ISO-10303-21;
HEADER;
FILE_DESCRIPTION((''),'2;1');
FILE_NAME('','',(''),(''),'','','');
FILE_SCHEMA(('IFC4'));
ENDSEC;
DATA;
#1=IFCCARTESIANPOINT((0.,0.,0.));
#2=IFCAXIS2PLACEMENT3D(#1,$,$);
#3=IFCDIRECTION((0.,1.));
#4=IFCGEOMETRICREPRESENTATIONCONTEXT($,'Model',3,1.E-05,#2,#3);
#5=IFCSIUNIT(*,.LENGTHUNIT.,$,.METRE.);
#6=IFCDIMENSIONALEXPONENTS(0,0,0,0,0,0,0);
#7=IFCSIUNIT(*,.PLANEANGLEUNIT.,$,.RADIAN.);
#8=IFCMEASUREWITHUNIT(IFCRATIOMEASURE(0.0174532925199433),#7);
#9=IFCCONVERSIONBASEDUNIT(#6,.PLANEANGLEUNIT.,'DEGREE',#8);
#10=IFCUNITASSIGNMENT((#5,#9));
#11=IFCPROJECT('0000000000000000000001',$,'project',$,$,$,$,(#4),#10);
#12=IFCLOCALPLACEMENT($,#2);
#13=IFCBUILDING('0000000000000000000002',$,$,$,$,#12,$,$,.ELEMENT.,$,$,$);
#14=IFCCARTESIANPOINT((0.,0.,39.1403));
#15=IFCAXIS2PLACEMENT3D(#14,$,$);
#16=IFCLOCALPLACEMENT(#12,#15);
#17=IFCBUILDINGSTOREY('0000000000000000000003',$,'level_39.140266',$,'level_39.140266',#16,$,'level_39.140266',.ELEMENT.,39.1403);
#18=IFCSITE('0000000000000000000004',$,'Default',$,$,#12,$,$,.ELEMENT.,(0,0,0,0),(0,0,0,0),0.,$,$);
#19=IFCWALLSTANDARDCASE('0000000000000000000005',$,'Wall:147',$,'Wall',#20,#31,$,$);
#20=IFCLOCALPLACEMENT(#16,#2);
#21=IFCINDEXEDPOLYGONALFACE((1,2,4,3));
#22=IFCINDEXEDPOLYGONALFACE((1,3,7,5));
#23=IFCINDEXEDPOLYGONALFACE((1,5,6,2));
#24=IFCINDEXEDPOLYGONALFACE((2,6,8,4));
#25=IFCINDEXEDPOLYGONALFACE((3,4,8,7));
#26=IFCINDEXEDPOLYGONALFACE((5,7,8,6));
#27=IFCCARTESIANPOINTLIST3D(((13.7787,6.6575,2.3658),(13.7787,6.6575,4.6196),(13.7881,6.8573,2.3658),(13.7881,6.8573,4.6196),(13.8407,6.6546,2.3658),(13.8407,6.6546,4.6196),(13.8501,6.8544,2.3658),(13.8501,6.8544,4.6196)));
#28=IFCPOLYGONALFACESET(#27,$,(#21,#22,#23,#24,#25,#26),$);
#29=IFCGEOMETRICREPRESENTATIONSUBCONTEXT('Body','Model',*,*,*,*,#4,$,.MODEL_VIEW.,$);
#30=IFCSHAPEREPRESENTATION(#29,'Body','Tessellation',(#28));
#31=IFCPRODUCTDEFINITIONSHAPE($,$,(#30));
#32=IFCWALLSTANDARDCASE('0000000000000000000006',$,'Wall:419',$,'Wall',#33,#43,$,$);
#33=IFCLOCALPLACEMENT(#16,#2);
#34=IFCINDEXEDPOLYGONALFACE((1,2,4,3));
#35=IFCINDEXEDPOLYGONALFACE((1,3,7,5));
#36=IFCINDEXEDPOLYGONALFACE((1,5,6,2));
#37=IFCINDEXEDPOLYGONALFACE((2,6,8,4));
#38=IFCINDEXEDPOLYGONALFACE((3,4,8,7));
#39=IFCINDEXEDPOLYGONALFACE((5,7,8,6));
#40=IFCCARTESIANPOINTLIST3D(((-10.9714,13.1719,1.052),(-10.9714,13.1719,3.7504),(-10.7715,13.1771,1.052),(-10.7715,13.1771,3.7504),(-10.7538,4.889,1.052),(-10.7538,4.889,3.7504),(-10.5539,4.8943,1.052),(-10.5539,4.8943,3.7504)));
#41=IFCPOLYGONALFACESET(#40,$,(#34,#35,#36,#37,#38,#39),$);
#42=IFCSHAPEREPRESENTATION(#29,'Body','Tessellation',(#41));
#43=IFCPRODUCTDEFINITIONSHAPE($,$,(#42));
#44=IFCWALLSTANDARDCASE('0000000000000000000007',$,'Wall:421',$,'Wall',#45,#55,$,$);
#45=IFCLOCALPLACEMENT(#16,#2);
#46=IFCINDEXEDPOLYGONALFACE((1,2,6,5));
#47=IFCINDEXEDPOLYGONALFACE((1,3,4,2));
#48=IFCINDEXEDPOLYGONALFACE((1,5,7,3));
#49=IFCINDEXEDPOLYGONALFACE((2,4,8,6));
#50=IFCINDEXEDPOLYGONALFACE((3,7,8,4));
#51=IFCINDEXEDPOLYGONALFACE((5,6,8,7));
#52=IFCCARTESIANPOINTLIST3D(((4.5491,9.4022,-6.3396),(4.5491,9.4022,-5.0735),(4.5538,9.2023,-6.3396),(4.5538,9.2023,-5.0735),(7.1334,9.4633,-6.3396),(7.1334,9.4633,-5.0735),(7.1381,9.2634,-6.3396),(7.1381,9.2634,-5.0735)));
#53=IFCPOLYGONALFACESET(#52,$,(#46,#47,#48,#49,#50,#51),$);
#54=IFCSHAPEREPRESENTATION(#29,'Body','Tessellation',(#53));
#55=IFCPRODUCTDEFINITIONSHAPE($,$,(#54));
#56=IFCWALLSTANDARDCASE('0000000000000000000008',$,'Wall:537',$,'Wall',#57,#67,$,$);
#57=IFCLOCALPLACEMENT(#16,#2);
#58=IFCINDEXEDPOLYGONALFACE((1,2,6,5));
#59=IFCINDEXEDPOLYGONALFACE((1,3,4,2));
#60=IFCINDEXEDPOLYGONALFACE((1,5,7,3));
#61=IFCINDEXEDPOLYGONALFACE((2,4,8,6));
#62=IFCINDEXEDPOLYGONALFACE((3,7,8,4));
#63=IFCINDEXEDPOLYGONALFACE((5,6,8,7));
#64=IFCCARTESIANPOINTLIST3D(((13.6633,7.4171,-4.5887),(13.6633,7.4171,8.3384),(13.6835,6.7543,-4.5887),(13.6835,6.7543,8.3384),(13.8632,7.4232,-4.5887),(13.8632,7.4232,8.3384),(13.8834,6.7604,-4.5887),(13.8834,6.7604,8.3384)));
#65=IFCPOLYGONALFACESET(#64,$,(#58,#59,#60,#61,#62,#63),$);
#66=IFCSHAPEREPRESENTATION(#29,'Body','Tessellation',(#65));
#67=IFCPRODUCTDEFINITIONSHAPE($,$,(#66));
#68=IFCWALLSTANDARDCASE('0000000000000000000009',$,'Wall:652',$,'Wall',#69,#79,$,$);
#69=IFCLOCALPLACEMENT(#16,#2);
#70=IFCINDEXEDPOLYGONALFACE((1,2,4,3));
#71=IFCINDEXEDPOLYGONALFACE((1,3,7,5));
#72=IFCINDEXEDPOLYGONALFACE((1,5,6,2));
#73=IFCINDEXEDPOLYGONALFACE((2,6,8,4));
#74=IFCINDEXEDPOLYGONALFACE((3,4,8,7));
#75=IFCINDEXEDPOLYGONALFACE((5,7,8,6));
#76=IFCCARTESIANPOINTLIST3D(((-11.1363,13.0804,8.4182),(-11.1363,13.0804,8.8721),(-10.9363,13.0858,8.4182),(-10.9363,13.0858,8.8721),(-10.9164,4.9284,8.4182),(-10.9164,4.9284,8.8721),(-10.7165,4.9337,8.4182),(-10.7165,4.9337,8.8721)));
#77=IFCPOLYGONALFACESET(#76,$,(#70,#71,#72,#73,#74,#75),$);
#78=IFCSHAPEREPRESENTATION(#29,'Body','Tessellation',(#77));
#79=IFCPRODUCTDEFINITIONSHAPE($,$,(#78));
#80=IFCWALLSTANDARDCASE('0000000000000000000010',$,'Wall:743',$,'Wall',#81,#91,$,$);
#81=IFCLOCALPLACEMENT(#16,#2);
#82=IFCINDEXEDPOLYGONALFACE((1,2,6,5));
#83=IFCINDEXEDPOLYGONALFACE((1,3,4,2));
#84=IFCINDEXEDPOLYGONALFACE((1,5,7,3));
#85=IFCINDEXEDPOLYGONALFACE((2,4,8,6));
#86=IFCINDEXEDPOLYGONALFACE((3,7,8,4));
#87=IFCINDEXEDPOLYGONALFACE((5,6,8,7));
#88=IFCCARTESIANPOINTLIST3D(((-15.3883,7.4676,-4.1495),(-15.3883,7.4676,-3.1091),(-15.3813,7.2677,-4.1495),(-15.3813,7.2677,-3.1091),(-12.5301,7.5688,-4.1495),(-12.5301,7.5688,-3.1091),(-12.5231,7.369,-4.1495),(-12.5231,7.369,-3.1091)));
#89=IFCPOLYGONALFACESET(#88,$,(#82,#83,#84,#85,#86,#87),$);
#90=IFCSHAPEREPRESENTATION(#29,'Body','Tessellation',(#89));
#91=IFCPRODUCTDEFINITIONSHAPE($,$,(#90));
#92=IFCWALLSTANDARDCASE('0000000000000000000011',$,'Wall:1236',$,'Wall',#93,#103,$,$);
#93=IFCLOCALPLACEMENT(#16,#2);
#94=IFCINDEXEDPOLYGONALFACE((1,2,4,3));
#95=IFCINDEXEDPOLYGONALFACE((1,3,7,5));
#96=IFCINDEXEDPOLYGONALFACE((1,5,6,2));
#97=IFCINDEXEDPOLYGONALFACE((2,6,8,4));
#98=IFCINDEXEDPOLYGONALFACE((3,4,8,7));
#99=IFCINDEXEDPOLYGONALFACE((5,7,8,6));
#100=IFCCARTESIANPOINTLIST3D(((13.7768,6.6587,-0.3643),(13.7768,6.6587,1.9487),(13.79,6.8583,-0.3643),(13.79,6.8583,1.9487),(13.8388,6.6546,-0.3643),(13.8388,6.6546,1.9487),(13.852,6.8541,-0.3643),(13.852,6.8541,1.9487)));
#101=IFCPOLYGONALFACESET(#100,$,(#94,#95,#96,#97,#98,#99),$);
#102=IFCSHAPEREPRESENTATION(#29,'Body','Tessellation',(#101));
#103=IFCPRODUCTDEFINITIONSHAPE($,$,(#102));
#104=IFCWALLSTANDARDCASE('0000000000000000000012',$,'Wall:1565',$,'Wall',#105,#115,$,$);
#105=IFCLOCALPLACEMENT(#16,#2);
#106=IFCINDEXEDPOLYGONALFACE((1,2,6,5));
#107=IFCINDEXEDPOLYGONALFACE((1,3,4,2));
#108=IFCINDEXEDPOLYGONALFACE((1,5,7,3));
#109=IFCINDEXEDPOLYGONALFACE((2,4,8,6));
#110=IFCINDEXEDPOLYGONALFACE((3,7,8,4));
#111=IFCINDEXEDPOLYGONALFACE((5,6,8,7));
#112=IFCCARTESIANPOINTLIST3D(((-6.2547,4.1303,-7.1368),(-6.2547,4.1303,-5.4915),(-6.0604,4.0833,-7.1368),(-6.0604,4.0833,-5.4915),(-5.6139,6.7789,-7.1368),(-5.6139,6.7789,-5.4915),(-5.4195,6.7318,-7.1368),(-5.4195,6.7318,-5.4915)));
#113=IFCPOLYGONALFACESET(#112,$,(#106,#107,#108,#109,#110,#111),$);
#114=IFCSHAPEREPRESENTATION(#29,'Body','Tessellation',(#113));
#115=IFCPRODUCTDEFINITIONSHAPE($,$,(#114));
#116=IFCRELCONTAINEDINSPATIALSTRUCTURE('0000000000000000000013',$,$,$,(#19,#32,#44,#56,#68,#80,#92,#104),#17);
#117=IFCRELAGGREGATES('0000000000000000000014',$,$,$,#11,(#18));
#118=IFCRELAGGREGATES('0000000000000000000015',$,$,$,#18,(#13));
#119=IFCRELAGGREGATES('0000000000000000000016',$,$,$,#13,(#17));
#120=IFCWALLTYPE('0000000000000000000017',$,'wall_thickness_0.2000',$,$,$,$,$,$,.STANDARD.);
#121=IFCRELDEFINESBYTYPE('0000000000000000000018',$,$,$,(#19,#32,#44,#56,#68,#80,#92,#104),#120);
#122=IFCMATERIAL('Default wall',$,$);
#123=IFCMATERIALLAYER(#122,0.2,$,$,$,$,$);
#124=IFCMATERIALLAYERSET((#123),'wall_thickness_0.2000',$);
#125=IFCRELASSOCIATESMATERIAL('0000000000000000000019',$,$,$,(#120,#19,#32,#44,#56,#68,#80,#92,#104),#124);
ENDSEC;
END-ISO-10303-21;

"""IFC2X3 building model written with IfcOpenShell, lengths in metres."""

from ifc_helpers import new_model, entity, si_unit, converted_unit, direction, frame, origin, place, context, subcontext, project, spatial, polyline, outline, extrude, material, layer, layer_set, layer_usage, type_object, element, save


model = new_model("IFC2X3")

# Units and contexts
model_context = context("Model", 3, precision=1e-05, world=origin(), true_north=direction((0.0, 1.0)))
body_context = subcontext(model_context, "Body", "Model", "MODEL_VIEW")
ifc_project = project(units=[si_unit("LENGTHUNIT", "METRE"), converted_unit("PLANEANGLEUNIT", "DEGREE", entity("IfcRatioMeasure", 0.0174532925199433), si_unit("PLANEANGLEUNIT", "RADIAN"), dimensions=[0, 0, 0, 0, 0, 0, 0])], contexts=[model_context])

# Site, building, storey
placement_1 = place(None, origin())
site = spatial("IfcSite", under=ifc_project, at=placement_1, Name="Default", CompositionType="ELEMENT", RefLatitude=(0, 0, 0, 0), RefLongitude=(0, 0, 0, 0), RefElevation=0.0)
building = spatial("IfcBuilding", under=site, at=placement_1, CompositionType="ELEMENT")
storey_placement = place(placement_1, frame((0.0, 0.0, 39.1403)))
storey = spatial("IfcBuildingStorey", under=building, at=storey_placement, Name="level_39.140266", ObjectType="level_39.140266", LongName="level_39.140266", CompositionType="ELEMENT", Elevation=39.1403)

# Walls
ifc_material = material(Name="Default wall")
ifc_layer = layer(ifc_material, 0.2)
ifc_layer_set = layer_set([ifc_layer], Name="wall_thickness_0.2000")
ifc_layer_usage = layer_usage(ifc_layer_set, "AXIS2", "POSITIVE", -0.1)
wall_type = type_object("IfcWallType", Name="wall_thickness_0.2000", PredefinedType="STANDARD", material=ifc_layer_set)
placement_2 = place(placement_1, frame((0.0, 0.0, 41.5061)))
wall_1_placement = place(placement_2, frame((13.8454, 6.7545, 0.0), z_axis=(0.0, 0.0, 1.0), x_axis=(-0.998909, 0.046707, 0.0)))
element("IfcWallStandardCase", 1, at=wall_1_placement, inside=storey, type_object=wall_type, material=ifc_layer_usage, Name="Wall:147", ObjectType="Wall", context=body_context, shape_type="SweptSolid", body=[
    extrude(outline(polyline([(0.062, -0.1), (0.062, 0.1), (0.0, 0.1), (0.0, -0.1), (0.062, -0.1)])), origin(), (0.0, 0.0, 1.0), 2.2538),
])
placement_3 = place(placement_1, frame((0.0, 0.0, 40.1923)))
wall_2_placement = place(placement_3, frame((-10.6538, 4.8916, 0.0), z_axis=(0.0, 0.0, 1.0), x_axis=(-0.026265, 0.999655, 0.0)))
element("IfcWallStandardCase", 2, at=wall_2_placement, inside=storey, type_object=wall_type, material=ifc_layer_usage, Name="Wall:419", ObjectType="Wall", context=body_context, shape_type="SweptSolid", body=[
    extrude(outline(polyline([(8.2857, -0.1), (8.2857, 0.1), (0.0, 0.1), (0.0, -0.1), (8.2857, -0.1)])), origin(), (0.0, 0.0, 1.0), 2.6984),
])
placement_4 = place(placement_1, frame((0.0, 0.0, 32.8007)))
wall_3_placement = place(placement_4, frame((4.5514, 9.3023, 0.0), z_axis=(0.0, 0.0, 1.0), x_axis=(0.999721, 0.023635, 0.0)))
element("IfcWallStandardCase", 3, at=wall_3_placement, inside=storey, type_object=wall_type, material=ifc_layer_usage, Name="Wall:421", ObjectType="Wall", context=body_context, shape_type="SweptSolid", body=[
    extrude(outline(polyline([(2.585, -0.1), (2.585, 0.1), (0.0, 0.1), (0.0, -0.1), (2.585, -0.1)])), origin(), (0.0, 0.0, 1.0), 1.2661),
])
placement_5 = place(placement_1, frame((0.0, 0.0, 34.5516)))
wall_4_placement = place(placement_5, frame((13.7834, 6.7574, 0.0), z_axis=(0.0, 0.0, 1.0), x_axis=(-0.030421, 0.999537, 0.0)))
element("IfcWallStandardCase", 4, at=wall_4_placement, inside=storey, type_object=wall_type, material=ifc_layer_usage, Name="Wall:537", ObjectType="Wall", context=body_context, shape_type="SweptSolid", body=[
    extrude(outline(polyline([(0.6631, -0.1), (0.6631, 0.1), (0.0, 0.1), (0.0, -0.1), (0.6631, -0.1)])), origin(), (0.0, 0.0, 1.0), 12.9271),
])
placement_6 = place(placement_1, frame((0.0, 0.0, 47.5585)))
wall_5_placement = place(placement_6, frame((-11.0363, 13.0831, 0.0), z_axis=(0.0, 0.0, 1.0), x_axis=(0.026962, -0.999636, 0.0)))
element("IfcWallStandardCase", 5, at=wall_5_placement, inside=storey, type_object=wall_type, material=ifc_layer_usage, Name="Wall:652", ObjectType="Wall", context=body_context, shape_type="SweptSolid", body=[
    extrude(outline(polyline([(8.155, -0.1), (8.155, 0.1), (0.0, 0.1), (0.0, -0.1), (8.155, -0.1)])), origin(), (0.0, 0.0, 1.0), 0.4539),
])
placement_7 = place(placement_1, frame((0.0, 0.0, 34.9908)))
wall_6_placement = place(placement_7, frame((-15.3848, 7.3676, 0.0), z_axis=(0.0, 0.0, 1.0), x_axis=(0.999373, 0.035404, 0.0)))
element("IfcWallStandardCase", 6, at=wall_6_placement, inside=storey, type_object=wall_type, material=ifc_layer_usage, Name="Wall:743", ObjectType="Wall", context=body_context, shape_type="SweptSolid", body=[
    extrude(outline(polyline([(2.86, -0.1), (2.86, 0.1), (0.0, 0.1), (0.0, -0.1), (2.86, -0.1)])), origin(), (0.0, 0.0, 1.0), 1.0403),
])
placement_8 = place(placement_1, frame((0.0, 0.0, 38.776)))
wall_7_placement = place(placement_8, frame((13.8454, 6.7544, 0.0), z_axis=(0.0, 0.0, 1.0), x_axis=(-0.997806, 0.066205, 0.0)))
element("IfcWallStandardCase", 7, at=wall_7_placement, inside=storey, type_object=wall_type, material=ifc_layer_usage, Name="Wall:1236", ObjectType="Wall", context=body_context, shape_type="SweptSolid", body=[
    extrude(outline(polyline([(0.0621, -0.1), (0.0621, 0.1), (0.0, 0.1), (0.0, -0.1), (0.0621, -0.1)])), origin(), (0.0, 0.0, 1.0), 2.3129),
])
placement_9 = place(placement_1, frame((0.0, 0.0, 32.0035)))
wall_8_placement = place(placement_9, frame((-5.5167, 6.7554, 0.0), z_axis=(0.0, 0.0, 1.0), x_axis=(-0.235187, -0.97195, 0.0)))
element("IfcWallStandardCase", 8, at=wall_8_placement, inside=storey, type_object=wall_type, material=ifc_layer_usage, Name="Wall:1565", ObjectType="Wall", context=body_context, shape_type="SweptSolid", body=[
    extrude(outline(polyline([(2.725, -0.1), (2.725, 0.1), (0.0, 0.1), (0.0, -0.1), (2.725, -0.1)])), origin(), (0.0, 0.0, 1.0), 1.6453),
])

save(model, "model.ifc")
